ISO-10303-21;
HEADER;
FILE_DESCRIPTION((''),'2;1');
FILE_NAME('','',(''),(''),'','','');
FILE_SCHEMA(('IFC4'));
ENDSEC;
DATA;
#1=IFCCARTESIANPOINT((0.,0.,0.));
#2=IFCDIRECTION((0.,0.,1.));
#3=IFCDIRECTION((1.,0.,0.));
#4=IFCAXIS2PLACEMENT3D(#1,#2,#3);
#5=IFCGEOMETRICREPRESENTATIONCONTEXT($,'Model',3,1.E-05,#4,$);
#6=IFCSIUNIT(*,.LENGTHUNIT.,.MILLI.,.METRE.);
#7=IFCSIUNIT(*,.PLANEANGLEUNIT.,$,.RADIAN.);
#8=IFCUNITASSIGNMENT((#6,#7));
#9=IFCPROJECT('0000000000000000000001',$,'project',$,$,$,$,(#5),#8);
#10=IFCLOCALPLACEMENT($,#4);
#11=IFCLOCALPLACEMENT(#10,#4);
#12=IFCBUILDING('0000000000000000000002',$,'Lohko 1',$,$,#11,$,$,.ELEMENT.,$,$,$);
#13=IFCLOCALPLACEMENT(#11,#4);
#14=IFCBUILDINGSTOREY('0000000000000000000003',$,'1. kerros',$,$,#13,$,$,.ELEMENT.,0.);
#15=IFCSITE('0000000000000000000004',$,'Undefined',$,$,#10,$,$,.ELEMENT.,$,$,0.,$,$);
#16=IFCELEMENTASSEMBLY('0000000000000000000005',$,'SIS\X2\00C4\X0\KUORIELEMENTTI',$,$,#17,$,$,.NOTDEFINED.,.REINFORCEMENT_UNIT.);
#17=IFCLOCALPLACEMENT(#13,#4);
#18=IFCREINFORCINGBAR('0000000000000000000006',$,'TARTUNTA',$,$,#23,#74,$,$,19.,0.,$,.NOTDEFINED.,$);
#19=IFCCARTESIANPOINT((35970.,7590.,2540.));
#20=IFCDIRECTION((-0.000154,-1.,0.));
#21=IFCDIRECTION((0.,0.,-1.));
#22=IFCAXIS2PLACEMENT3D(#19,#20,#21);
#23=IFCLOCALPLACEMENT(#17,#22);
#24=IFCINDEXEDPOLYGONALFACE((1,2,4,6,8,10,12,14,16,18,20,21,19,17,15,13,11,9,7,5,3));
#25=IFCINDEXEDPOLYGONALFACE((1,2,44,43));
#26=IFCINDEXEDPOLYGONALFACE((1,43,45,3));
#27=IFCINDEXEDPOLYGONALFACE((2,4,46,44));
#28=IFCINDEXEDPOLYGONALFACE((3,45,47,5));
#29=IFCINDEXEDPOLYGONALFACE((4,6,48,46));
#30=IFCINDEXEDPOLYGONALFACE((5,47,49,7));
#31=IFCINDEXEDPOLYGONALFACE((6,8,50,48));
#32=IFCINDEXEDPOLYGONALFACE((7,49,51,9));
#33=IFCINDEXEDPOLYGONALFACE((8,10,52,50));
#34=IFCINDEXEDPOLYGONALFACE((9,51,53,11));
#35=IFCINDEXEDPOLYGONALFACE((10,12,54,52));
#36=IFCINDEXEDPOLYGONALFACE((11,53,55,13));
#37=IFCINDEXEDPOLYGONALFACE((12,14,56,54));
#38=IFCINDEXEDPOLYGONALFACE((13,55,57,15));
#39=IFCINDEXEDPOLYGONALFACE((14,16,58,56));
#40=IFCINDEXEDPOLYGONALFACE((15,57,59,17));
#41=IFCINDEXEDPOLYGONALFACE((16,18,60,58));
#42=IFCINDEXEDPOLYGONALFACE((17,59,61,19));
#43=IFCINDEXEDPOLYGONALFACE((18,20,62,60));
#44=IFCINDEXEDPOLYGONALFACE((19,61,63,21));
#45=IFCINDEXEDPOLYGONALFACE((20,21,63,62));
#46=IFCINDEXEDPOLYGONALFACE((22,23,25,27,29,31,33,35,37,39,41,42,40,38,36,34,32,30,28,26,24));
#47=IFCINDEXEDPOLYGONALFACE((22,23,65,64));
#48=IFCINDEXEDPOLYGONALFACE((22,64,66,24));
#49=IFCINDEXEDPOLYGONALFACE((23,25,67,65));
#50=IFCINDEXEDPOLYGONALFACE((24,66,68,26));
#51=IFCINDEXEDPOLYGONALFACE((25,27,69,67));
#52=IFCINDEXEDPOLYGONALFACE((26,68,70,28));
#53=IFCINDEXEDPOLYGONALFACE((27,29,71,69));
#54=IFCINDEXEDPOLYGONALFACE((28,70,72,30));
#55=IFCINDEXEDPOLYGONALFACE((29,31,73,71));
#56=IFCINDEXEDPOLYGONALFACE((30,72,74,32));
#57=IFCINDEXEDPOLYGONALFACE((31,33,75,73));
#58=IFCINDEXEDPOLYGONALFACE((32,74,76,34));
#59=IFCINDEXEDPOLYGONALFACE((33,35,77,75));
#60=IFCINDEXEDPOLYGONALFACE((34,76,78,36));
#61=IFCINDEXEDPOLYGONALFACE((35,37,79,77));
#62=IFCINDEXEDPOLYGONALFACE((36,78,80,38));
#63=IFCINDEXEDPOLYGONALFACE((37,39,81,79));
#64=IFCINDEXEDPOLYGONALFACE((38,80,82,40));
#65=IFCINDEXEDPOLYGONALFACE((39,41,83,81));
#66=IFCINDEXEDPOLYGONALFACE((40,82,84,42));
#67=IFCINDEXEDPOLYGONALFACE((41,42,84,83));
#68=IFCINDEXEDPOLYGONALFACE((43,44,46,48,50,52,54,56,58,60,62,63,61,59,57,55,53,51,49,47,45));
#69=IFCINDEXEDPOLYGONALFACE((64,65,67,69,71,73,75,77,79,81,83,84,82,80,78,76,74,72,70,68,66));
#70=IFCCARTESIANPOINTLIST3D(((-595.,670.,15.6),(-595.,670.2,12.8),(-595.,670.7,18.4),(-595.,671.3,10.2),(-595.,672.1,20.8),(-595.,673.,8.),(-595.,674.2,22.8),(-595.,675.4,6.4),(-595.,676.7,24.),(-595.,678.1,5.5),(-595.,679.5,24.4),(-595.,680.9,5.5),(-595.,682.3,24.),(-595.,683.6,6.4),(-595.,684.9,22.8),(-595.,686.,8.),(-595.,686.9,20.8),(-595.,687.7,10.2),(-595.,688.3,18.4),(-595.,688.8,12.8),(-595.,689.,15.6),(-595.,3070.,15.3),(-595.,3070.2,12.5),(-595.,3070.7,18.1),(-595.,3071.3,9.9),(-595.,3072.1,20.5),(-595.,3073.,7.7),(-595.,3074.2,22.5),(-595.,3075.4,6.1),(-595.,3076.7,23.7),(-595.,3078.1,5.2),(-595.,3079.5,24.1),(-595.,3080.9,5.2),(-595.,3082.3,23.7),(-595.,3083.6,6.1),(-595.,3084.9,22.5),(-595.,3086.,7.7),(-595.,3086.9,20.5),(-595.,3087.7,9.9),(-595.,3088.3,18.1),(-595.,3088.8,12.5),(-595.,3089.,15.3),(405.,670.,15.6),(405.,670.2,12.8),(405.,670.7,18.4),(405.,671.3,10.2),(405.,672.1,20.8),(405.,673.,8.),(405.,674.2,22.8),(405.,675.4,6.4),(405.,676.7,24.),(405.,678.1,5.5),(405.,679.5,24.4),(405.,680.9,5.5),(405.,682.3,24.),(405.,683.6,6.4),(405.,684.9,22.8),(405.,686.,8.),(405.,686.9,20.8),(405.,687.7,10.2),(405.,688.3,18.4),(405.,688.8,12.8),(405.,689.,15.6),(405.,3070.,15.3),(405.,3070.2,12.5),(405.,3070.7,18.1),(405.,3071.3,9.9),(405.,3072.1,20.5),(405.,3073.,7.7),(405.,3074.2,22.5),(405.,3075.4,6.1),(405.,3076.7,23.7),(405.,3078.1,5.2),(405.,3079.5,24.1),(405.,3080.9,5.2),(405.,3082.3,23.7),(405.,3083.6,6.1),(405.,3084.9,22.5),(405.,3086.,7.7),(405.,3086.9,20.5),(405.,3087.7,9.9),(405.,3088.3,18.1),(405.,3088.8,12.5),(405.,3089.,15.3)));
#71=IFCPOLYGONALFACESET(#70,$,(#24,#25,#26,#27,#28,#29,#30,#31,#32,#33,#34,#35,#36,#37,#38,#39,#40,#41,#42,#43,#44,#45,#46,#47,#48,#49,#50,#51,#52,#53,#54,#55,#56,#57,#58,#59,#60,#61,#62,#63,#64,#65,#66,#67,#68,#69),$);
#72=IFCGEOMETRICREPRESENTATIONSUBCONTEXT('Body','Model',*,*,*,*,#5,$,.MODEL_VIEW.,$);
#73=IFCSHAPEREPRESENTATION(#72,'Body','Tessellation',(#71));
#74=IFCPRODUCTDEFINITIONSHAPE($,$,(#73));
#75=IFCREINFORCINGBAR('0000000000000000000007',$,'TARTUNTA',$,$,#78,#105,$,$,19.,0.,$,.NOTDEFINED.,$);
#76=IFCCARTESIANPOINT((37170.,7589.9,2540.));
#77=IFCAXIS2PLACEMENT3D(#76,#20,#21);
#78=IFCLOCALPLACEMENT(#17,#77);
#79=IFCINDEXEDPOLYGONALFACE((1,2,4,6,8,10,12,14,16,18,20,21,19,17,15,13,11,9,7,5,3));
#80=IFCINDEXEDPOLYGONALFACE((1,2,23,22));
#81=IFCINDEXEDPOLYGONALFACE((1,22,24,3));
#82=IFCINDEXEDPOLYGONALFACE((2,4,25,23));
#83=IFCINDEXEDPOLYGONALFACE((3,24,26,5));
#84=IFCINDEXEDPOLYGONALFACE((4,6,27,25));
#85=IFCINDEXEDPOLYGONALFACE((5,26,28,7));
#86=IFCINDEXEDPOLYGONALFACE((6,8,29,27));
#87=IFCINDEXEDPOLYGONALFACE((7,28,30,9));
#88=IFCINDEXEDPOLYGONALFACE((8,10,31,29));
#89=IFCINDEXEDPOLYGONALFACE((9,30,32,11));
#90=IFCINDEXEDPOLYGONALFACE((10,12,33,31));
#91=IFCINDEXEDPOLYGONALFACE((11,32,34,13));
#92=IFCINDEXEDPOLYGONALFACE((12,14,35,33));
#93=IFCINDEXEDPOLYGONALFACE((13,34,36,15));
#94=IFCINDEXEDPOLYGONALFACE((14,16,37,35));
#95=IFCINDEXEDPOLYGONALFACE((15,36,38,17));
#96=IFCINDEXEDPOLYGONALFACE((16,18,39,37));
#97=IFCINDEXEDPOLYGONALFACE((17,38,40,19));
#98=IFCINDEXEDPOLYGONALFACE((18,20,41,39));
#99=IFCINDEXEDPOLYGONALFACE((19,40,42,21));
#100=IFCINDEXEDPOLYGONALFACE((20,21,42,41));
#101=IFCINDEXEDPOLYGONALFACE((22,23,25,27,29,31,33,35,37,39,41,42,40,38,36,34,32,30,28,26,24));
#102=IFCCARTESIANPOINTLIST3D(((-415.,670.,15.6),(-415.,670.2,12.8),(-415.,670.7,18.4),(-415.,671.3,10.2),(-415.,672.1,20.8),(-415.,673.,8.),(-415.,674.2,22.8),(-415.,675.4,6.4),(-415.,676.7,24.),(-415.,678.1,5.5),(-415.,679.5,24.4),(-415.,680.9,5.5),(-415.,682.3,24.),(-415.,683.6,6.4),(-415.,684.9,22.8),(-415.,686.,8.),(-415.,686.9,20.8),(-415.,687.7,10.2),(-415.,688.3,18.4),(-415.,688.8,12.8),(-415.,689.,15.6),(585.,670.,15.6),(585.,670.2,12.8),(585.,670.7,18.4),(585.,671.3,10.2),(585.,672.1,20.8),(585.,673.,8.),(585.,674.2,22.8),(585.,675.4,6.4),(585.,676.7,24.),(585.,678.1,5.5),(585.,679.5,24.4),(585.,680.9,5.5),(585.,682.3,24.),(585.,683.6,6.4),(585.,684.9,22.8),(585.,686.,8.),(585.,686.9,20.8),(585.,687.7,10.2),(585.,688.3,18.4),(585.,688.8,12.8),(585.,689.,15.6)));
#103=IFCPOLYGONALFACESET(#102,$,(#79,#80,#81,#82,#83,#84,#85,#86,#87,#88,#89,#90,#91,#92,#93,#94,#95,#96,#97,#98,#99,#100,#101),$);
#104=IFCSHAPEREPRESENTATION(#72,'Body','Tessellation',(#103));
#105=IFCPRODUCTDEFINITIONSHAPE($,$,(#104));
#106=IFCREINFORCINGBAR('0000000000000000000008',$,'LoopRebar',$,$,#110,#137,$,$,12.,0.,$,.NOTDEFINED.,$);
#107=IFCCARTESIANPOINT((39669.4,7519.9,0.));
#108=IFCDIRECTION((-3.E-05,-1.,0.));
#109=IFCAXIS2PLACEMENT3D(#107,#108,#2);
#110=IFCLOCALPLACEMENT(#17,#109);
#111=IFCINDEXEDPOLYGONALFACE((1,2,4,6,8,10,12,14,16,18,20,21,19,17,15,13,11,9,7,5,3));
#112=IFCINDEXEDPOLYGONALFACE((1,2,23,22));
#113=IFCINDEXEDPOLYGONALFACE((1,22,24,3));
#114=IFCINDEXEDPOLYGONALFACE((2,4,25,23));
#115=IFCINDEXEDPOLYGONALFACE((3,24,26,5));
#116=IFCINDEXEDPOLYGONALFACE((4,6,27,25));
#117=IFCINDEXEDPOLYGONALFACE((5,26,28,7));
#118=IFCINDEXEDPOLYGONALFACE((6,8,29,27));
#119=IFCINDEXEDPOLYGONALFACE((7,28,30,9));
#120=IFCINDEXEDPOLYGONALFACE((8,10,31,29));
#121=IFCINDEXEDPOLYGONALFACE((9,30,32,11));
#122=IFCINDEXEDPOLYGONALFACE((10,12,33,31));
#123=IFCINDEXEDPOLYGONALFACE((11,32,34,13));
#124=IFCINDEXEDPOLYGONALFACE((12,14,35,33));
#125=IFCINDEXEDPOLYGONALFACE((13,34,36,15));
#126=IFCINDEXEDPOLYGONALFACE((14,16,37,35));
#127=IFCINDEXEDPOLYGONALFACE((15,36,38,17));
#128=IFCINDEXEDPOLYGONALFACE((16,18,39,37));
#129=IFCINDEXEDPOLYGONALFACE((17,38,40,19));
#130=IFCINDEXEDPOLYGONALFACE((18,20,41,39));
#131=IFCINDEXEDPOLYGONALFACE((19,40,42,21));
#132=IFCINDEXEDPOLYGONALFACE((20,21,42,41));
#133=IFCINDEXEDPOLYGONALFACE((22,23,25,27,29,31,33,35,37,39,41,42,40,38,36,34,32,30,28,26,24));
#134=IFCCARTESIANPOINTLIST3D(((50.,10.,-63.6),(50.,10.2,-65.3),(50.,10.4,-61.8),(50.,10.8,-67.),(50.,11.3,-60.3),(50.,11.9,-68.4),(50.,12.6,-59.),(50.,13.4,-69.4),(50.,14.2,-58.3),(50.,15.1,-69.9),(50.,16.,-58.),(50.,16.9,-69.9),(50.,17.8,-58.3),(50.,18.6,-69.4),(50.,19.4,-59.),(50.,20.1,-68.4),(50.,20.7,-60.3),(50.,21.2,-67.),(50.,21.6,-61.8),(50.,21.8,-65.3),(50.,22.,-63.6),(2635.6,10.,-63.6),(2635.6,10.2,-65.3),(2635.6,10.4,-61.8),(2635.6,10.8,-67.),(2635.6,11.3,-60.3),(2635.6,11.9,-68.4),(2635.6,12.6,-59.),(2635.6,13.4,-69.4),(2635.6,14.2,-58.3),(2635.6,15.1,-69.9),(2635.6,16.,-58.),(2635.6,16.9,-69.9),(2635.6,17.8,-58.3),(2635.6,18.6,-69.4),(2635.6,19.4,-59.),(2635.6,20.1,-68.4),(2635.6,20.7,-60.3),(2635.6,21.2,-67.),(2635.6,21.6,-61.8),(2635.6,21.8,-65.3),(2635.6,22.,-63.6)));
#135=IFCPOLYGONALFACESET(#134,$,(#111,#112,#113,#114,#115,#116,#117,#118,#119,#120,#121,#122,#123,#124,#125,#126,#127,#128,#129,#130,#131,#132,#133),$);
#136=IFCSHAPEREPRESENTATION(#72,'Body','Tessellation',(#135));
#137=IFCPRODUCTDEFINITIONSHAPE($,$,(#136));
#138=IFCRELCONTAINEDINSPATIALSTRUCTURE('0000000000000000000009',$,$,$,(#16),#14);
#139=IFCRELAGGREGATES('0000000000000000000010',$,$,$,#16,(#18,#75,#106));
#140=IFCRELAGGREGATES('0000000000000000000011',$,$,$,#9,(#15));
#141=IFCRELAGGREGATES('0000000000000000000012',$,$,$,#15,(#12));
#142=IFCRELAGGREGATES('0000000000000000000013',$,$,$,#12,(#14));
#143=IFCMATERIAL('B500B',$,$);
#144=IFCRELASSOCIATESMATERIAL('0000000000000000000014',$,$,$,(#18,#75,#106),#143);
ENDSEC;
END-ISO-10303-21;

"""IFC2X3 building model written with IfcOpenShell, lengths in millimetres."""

from ifc_helpers import new_model, entity, si_unit, frame, origin_with_axes, place, context, subcontext, project, spatial, source, transform, mapped, material, element, aggregate, save


model = new_model("IFC2X3")

# Units and contexts
model_context = context("Model", 3, precision=1e-05, world=origin_with_axes())
body_context = subcontext(model_context, "Body", "Model", "MODEL_VIEW")
ifc_project = project(units=[si_unit("LENGTHUNIT", "METRE", prefix="MILLI"), si_unit("PLANEANGLEUNIT", "RADIAN")], contexts=[model_context])

# Site, building, storey
site_placement = place(None, origin_with_axes())
site = spatial("IfcSite", under=ifc_project, at=site_placement, Name="Undefined", CompositionType="ELEMENT", RefElevation=0.0)
building_placement = place(site_placement, origin_with_axes())
building = spatial("IfcBuilding", under=site, at=building_placement, Name="Lohko 1", CompositionType="ELEMENT")
storey_placement = place(building_placement, origin_with_axes())
storey = spatial("IfcBuildingStorey", under=building, at=storey_placement, Name="1. kerros", CompositionType="ELEMENT", Elevation=0.0)

# Element assembly, reinforcing bars
assembly_placement = place(storey_placement, origin_with_axes())
assembly = element("IfcElementAssembly", 1, at=assembly_placement, inside=storey, Name="SISÄKUORIELEMENTTI", AssemblyPlace="NOTDEFINED", PredefinedType="REINFORCEMENT_UNIT")
ifc_material_1 = material(Name="B500B")
shared_shape_1 = source(origin_with_axes(), body_context, "Body", "AdvancedSweptSolid", [
    entity("IfcSweptDiskSolid", entity("IfcTrimmedCurve", entity("IfcLine", entity("IfcCartesianPoint", [0.0, 0.0, 0.0]), entity("IfcVector", entity("IfcDirection", [1.0, 0.0, 0.0]), 1.0)), [entity("IfcParameterValue", 0.0)], [entity("IfcParameterValue", 1000.0)], True, "PARAMETER"), 9.5, None, 0.0, 1000.0),
])
shared_shape_2 = source(origin_with_axes(), body_context, "Body", "AdvancedSweptSolid", [
    entity("IfcSweptDiskSolid", entity("IfcTrimmedCurve", entity("IfcLine", entity("IfcCartesianPoint", [0.0, 0.0, 0.0]), entity("IfcVector", entity("IfcDirection", [1.0, 0.0, 0.0]), 1.0)), [entity("IfcParameterValue", 0.0)], [entity("IfcParameterValue", 1000.0)], True, "PARAMETER"), 9.5, None, 0.0, 1000.0),
])
reinforcing_bar_1_placement = place(assembly_placement, frame((35970.0, 7590.0, 2540.0), z_axis=(-0.000154, -1.0, 0.0), x_axis=(0.0, 0.0, -1.0)))
reinforcing_bar_1 = element("IfcReinforcingBar", 2, at=reinforcing_bar_1_placement, material=ifc_material_1, Name="TARTUNTA", BarRole="NOTDEFINED", CrossSectionArea=0.0, NominalDiameter=19.0, context=body_context, shape_type="MappedRepresentation", body=[
    mapped(shared_shape_1, transform((-595.0, 679.5, 14.9))),
    mapped(shared_shape_2, transform((-595.0, 3079.5, 14.6))),
])
shared_shape_3 = source(origin_with_axes(), body_context, "Body", "AdvancedSweptSolid", [
    entity("IfcSweptDiskSolid", entity("IfcTrimmedCurve", entity("IfcLine", entity("IfcCartesianPoint", [0.0, 0.0, 0.0]), entity("IfcVector", entity("IfcDirection", [1.0, 0.0, 0.0]), 1.0)), [entity("IfcParameterValue", 0.0)], [entity("IfcParameterValue", 1000.0)], True, "PARAMETER"), 9.5, None, 0.0, 1000.0),
])
reinforcing_bar_2_placement = place(assembly_placement, frame((37170.0, 7589.9, 2540.0), z_axis=(-0.000154, -1.0, 0.0), x_axis=(0.0, 0.0, -1.0)))
reinforcing_bar_2 = element("IfcReinforcingBar", 3, at=reinforcing_bar_2_placement, material=ifc_material_1, Name="TARTUNTA", BarRole="NOTDEFINED", CrossSectionArea=0.0, NominalDiameter=19.0, context=body_context, shape_type="MappedRepresentation", body=[
    mapped(shared_shape_3, transform((-415.0, 679.5, 14.9))),
])
shared_shape_4 = source(origin_with_axes(), body_context, "Body", "AdvancedSweptSolid", [
    entity("IfcSweptDiskSolid", entity("IfcTrimmedCurve", entity("IfcLine", entity("IfcCartesianPoint", [0.0, 0.0, 0.0]), entity("IfcVector", entity("IfcDirection", [1.0, 0.0, 0.0]), 1.0)), [entity("IfcParameterValue", 0.0)], [entity("IfcParameterValue", 2585.644988)], True, "PARAMETER"), 6.0, None, 0.0, 2585.6),
])
reinforcing_bar_3_placement = place(assembly_placement, frame((39669.4, 7519.9, 0.0), z_axis=(-0.00003, -1.0, 0.0), x_axis=(0.0, 0.0, 1.0)))
reinforcing_bar_3 = element("IfcReinforcingBar", 4, at=reinforcing_bar_3_placement, material=ifc_material_1, Name="LoopRebar", BarRole="NOTDEFINED", CrossSectionArea=0.0, NominalDiameter=12.0, context=body_context, shape_type="MappedRepresentation", body=[
    mapped(shared_shape_4, transform((50.0, 16.0, -64.0))),
])
aggregate(assembly, [reinforcing_bar_1, reinforcing_bar_2, reinforcing_bar_3])

save(model, "model.ifc")
